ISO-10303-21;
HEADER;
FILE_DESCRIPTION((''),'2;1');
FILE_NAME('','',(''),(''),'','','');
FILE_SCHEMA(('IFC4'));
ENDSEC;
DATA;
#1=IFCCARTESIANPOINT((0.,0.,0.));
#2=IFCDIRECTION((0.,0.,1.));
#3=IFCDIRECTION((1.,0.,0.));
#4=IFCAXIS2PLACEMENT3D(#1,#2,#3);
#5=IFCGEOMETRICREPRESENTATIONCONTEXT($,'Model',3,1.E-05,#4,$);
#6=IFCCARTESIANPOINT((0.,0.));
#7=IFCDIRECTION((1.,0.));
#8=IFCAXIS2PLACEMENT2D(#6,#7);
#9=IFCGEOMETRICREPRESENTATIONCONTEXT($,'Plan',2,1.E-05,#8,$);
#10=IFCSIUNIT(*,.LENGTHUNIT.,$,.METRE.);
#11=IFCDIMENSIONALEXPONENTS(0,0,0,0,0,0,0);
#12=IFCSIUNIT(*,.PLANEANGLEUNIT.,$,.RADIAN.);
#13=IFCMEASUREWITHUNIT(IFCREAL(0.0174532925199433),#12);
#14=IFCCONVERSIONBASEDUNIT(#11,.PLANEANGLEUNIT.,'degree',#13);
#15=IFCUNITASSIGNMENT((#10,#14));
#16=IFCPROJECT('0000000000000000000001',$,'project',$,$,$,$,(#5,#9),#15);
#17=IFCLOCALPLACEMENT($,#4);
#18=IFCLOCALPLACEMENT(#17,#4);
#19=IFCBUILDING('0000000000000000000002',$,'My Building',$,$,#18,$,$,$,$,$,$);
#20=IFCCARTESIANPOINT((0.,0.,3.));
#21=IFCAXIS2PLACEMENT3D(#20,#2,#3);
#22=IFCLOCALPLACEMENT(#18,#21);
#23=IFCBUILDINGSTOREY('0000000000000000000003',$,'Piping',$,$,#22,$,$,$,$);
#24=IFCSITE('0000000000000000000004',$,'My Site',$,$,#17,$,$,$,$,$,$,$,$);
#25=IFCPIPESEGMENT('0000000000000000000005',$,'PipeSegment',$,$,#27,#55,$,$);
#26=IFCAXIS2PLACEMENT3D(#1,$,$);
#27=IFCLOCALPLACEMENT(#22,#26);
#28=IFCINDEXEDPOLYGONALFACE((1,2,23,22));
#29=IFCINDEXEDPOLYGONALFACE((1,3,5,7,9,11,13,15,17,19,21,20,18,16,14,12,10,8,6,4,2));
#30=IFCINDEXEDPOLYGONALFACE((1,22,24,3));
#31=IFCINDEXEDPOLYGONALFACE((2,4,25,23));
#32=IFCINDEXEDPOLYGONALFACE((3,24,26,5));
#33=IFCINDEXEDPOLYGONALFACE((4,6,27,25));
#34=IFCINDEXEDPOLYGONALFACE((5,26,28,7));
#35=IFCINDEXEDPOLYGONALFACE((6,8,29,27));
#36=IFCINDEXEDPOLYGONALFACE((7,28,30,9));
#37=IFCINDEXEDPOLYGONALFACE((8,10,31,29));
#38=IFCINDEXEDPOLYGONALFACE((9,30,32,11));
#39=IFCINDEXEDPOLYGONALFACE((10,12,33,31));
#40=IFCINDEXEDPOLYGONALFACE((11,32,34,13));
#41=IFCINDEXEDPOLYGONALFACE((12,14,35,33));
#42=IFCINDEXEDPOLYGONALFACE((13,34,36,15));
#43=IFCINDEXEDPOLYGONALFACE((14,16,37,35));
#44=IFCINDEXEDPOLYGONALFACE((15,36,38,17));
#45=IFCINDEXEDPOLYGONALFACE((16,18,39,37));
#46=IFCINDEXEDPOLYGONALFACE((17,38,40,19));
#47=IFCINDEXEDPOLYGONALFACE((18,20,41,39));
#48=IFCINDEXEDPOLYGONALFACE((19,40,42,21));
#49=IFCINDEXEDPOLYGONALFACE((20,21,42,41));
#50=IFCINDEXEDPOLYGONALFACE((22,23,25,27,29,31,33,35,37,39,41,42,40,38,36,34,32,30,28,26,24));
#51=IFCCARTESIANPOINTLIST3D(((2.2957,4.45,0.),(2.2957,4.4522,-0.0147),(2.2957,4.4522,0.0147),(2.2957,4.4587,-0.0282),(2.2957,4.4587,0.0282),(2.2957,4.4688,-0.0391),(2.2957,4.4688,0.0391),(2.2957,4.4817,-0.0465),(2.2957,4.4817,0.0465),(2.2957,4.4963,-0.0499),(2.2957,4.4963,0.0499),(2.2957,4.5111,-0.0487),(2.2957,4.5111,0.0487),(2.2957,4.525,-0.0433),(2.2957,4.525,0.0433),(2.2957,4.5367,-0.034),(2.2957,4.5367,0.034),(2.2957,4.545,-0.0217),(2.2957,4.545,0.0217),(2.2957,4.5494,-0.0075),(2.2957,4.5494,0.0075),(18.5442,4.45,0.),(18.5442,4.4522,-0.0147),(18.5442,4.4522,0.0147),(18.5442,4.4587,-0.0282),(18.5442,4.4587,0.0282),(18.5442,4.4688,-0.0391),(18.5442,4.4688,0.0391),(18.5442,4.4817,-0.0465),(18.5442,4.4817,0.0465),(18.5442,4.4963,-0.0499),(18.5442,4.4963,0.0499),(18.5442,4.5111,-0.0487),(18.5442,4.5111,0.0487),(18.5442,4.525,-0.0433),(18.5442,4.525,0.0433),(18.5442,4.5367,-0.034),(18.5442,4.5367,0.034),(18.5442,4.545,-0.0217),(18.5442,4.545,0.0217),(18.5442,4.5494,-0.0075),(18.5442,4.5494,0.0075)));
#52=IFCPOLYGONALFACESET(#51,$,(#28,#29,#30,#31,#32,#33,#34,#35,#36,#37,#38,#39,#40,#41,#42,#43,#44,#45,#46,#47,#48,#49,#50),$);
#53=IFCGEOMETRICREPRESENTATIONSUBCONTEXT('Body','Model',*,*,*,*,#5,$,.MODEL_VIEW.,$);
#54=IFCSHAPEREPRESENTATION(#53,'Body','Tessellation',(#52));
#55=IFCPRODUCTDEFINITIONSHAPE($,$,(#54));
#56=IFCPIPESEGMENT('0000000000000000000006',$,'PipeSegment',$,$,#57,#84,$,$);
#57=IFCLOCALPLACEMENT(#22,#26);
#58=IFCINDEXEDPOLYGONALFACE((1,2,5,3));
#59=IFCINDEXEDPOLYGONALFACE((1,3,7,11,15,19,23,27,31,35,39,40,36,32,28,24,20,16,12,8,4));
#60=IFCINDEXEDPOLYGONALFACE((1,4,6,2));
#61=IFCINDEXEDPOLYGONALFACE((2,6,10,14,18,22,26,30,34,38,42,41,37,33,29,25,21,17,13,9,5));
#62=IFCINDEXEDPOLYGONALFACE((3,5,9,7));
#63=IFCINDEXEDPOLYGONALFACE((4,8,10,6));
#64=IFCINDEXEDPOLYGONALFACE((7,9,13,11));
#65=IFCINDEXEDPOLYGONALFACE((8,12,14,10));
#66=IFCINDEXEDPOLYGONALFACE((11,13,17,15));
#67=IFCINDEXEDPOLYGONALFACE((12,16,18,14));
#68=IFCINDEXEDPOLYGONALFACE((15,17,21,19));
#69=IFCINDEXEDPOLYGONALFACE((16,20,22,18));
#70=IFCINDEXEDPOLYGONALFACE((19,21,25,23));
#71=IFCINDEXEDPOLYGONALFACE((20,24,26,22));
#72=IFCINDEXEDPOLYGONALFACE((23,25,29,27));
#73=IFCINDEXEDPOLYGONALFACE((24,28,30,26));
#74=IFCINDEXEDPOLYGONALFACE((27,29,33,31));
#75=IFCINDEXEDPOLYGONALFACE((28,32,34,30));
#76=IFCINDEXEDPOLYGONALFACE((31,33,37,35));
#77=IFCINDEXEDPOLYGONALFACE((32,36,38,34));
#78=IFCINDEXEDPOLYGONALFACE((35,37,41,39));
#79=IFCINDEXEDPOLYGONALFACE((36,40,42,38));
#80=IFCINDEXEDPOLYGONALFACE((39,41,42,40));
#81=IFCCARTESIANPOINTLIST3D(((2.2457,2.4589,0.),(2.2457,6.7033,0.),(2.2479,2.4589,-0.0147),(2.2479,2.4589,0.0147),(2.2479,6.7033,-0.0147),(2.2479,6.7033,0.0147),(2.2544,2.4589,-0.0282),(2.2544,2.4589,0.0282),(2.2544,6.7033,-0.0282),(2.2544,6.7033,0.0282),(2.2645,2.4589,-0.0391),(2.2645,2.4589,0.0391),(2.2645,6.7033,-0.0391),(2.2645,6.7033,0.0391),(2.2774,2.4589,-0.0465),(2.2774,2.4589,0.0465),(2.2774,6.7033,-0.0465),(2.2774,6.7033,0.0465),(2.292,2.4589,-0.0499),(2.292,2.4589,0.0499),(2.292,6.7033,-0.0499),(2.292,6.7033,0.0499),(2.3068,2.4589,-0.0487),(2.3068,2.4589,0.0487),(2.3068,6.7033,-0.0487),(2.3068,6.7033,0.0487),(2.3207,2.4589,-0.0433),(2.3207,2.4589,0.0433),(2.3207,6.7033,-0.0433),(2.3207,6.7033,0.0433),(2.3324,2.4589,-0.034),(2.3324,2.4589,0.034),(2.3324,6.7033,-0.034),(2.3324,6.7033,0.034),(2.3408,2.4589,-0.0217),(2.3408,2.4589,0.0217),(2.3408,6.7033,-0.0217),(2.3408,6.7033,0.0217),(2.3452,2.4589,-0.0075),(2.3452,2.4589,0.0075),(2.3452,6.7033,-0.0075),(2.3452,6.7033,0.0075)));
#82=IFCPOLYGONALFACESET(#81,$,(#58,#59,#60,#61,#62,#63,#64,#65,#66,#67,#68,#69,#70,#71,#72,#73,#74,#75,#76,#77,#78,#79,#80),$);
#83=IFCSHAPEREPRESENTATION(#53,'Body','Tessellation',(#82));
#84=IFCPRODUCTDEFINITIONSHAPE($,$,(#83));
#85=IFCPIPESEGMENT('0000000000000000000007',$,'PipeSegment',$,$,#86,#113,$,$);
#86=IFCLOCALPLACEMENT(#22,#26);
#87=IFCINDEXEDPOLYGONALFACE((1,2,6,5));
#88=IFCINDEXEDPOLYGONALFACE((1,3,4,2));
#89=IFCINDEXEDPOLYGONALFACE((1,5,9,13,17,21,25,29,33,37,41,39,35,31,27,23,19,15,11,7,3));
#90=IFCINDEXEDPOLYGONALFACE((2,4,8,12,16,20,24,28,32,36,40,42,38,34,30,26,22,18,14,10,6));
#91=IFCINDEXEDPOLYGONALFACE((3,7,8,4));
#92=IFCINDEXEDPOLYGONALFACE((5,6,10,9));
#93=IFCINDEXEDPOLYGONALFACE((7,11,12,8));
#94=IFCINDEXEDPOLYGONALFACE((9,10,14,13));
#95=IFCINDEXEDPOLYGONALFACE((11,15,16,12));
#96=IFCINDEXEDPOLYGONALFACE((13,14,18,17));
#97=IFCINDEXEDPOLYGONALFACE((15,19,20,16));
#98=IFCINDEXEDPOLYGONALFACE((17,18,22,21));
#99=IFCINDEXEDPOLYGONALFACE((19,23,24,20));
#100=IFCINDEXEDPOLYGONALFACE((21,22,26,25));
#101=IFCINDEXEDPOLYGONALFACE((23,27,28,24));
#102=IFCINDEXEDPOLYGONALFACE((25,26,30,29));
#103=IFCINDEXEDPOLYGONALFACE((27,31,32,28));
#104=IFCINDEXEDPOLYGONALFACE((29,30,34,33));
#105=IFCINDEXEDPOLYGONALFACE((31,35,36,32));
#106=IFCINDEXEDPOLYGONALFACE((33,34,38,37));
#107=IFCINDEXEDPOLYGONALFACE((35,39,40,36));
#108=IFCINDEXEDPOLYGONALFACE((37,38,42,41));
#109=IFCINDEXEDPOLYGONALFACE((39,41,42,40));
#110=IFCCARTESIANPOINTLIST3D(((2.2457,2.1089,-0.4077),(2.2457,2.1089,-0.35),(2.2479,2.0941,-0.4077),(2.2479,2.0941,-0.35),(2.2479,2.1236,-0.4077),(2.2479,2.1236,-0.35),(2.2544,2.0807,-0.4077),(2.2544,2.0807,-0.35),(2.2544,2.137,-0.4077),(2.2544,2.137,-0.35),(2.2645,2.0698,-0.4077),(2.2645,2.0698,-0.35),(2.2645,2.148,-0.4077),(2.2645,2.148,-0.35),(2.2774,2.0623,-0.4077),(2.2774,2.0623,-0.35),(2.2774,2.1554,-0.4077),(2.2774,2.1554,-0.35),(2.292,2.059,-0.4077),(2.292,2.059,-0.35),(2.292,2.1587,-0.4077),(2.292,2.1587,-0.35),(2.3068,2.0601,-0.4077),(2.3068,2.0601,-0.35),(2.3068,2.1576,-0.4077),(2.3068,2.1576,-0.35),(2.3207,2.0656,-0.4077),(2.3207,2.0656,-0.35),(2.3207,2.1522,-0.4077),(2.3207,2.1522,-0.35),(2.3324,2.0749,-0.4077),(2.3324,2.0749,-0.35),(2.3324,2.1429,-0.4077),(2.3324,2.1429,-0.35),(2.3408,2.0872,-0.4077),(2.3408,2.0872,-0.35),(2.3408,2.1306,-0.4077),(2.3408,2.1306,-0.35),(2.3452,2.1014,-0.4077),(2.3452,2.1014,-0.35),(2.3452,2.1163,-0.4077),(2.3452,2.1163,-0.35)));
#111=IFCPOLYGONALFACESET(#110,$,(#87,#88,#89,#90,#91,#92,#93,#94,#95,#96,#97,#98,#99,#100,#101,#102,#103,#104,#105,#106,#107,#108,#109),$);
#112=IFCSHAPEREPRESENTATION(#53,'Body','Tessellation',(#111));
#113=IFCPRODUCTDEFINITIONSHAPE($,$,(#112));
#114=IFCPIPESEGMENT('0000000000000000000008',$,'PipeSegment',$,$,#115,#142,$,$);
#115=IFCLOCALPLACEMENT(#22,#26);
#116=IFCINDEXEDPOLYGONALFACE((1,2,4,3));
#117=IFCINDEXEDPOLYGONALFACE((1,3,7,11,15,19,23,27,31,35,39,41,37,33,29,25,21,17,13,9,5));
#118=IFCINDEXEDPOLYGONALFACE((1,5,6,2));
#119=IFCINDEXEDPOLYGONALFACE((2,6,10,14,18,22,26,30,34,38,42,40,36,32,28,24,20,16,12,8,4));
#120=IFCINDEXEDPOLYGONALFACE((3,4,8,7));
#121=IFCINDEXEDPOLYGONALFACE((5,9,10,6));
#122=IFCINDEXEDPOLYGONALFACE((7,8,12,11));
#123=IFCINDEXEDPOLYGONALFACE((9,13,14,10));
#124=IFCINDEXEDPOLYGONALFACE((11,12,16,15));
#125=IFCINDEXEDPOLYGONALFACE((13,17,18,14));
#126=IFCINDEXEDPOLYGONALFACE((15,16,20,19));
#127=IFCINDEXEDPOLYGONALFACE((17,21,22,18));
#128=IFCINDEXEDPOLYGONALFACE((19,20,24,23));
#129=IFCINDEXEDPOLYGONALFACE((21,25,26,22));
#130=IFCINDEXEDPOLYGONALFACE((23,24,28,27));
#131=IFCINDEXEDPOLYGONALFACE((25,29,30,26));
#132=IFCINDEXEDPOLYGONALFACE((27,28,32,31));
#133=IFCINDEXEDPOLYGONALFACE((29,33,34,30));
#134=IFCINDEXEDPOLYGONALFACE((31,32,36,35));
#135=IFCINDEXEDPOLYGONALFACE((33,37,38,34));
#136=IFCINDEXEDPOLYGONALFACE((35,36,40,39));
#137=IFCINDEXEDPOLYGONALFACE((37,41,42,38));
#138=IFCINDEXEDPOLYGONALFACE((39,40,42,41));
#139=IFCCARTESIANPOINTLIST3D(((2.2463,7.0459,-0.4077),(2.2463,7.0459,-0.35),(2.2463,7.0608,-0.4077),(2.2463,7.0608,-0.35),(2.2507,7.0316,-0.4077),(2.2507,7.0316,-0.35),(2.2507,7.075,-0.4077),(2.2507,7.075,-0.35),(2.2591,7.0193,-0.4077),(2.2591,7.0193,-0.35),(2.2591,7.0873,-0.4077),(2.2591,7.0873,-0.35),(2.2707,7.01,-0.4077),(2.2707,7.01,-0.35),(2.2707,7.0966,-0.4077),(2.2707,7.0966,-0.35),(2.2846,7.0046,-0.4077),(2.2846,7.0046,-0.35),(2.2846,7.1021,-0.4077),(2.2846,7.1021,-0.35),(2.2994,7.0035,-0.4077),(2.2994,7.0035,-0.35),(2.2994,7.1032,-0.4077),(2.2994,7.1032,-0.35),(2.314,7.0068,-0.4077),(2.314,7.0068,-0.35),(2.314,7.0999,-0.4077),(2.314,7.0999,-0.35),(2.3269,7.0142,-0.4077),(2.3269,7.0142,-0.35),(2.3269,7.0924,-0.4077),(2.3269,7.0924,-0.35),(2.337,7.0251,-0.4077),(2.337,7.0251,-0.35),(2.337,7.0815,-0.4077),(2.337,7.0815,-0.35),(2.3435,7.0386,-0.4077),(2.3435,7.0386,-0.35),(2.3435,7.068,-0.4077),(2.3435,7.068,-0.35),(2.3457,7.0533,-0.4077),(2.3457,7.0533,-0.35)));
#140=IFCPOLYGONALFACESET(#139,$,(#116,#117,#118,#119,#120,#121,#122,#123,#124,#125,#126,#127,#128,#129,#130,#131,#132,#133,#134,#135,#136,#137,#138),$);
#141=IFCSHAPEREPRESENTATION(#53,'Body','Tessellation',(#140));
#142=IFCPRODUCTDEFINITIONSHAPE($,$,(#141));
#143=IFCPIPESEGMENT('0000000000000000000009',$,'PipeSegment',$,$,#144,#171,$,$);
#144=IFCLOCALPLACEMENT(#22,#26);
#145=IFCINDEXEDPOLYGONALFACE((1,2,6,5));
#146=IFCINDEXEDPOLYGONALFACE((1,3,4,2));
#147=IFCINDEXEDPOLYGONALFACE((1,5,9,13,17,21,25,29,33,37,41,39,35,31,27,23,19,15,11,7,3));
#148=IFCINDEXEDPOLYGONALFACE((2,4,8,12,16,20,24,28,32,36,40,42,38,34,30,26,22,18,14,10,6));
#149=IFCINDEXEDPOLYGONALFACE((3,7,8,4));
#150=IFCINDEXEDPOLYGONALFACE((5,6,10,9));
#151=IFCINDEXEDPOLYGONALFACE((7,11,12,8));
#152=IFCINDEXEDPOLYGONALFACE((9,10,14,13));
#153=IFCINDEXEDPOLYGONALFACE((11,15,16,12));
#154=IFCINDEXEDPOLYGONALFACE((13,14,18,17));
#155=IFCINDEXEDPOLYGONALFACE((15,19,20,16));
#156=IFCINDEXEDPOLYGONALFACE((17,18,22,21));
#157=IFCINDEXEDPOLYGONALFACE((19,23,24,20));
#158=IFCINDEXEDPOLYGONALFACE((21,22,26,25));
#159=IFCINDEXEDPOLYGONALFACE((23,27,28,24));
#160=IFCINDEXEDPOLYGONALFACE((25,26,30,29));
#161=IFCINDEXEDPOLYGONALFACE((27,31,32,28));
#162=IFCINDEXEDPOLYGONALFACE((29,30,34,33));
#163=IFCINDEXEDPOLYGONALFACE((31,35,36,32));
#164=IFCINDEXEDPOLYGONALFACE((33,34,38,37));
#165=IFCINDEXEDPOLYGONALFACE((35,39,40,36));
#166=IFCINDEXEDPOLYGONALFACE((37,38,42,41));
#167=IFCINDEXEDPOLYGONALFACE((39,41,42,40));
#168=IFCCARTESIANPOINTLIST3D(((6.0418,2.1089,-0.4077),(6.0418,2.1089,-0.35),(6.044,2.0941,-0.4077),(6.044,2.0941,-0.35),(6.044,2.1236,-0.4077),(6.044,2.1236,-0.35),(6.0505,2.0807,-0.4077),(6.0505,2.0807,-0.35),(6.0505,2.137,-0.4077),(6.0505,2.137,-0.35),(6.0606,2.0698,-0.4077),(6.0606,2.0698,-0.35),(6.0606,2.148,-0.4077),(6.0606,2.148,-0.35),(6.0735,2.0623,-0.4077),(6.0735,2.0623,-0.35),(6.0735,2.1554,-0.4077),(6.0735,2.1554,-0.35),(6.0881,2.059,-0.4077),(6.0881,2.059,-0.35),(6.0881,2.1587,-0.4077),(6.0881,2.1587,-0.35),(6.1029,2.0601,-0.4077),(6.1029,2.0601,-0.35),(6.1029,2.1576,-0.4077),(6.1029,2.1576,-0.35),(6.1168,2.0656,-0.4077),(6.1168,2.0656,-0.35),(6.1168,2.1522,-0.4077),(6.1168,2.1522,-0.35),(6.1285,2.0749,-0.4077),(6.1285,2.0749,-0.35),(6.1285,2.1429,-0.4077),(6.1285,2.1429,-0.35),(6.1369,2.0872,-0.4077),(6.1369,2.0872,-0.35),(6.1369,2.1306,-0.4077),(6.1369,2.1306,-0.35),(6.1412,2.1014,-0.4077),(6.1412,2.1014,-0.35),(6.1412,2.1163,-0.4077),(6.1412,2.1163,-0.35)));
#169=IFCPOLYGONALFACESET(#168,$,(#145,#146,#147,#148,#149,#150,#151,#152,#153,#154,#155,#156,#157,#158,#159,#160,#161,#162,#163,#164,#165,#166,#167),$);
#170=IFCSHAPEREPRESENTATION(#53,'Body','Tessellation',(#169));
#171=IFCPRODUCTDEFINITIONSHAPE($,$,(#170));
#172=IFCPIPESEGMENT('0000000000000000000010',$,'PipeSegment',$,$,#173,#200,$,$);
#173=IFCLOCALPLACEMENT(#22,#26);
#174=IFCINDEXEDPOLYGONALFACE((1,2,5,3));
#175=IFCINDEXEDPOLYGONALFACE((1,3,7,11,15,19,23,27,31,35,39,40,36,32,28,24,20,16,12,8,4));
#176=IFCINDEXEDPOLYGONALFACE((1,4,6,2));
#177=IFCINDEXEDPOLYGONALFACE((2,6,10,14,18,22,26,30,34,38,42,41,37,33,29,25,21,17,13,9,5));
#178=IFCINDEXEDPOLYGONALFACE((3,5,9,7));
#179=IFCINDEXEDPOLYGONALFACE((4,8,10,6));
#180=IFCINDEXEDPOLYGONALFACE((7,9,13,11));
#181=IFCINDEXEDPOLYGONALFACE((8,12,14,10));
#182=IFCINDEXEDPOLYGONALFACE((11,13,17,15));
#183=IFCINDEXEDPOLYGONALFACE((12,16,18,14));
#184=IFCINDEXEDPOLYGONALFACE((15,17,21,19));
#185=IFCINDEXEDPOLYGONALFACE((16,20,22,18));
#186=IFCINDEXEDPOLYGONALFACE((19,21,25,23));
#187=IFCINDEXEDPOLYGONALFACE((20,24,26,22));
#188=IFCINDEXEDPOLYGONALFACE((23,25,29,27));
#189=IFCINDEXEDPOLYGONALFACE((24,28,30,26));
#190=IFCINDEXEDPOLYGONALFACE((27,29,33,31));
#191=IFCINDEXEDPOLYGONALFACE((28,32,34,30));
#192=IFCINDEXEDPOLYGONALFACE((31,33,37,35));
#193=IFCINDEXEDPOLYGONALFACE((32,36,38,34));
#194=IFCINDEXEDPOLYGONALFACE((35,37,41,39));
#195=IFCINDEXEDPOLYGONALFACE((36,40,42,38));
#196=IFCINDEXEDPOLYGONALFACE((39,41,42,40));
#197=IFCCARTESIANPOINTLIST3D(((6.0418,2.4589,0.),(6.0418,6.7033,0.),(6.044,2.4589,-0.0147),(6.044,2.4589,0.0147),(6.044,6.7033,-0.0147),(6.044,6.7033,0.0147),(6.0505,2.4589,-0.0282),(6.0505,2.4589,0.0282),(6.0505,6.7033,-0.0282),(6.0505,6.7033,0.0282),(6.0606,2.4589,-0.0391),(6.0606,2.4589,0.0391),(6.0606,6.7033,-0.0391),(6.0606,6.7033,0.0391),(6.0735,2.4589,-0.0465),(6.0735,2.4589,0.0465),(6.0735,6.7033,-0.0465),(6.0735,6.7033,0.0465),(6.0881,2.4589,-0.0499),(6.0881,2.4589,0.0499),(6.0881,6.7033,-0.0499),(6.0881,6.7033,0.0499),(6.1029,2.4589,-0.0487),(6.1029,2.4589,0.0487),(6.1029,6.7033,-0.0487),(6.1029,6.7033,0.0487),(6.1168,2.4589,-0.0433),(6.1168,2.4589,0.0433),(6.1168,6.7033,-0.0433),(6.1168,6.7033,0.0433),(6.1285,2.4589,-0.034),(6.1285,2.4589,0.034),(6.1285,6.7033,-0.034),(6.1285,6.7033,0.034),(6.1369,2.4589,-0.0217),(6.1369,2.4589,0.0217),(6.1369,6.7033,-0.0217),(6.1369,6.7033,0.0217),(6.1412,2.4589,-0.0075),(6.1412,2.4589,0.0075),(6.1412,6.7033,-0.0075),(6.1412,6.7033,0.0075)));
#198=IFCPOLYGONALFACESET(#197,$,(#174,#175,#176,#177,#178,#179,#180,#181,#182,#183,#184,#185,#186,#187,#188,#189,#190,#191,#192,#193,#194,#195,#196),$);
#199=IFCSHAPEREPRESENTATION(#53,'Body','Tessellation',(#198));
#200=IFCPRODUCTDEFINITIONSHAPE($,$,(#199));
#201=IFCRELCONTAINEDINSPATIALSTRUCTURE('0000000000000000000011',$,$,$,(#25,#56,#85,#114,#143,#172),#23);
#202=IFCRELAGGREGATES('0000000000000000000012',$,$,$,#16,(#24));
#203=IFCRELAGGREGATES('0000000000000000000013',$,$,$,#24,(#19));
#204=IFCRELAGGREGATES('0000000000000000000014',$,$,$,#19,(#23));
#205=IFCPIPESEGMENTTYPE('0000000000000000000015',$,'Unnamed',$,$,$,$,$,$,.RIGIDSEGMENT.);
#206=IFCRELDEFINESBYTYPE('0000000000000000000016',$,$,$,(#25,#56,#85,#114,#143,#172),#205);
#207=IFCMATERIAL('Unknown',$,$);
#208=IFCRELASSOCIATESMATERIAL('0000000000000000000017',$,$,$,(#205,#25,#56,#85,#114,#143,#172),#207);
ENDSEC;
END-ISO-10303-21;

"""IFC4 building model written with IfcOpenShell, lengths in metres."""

from ifc_helpers import new_model, entity, si_unit, converted_unit, frame, origin_with_axes, origin_2d_with_axis, place, context, subcontext, project, spatial, circle, extrude, material, material_profile, profile_set, profile_usage, type_object, element, save


model = new_model("IFC4")

# Units and contexts
model_context = context("Model", 3, precision=1e-05, world=origin_with_axes())
plan_context = context("Plan", 2, precision=1e-05, world=origin_2d_with_axis())
body_context = subcontext(model_context, "Body", "Model", "MODEL_VIEW")
ifc_project = project(units=[si_unit("LENGTHUNIT", "METRE"), converted_unit("PLANEANGLEUNIT", "degree", entity("IfcReal", 0.0174532925199433), si_unit("PLANEANGLEUNIT", "RADIAN"), dimensions=[0, 0, 0, 0, 0, 0, 0])], contexts=[model_context, plan_context])

# Site, building, storey
site_placement = place(None, origin_with_axes())
site = spatial("IfcSite", under=ifc_project, at=site_placement, Name="My Site")
building_placement = place(site_placement, origin_with_axes())
building = spatial("IfcBuilding", under=site, at=building_placement, Name="My Building")
storey_placement = place(building_placement, frame((0.0, 0.0, 3.0), z_axis=(0.0, 0.0, 1.0), x_axis=(1.0, 0.0, 0.0)))
storey = spatial("IfcBuildingStorey", under=building, at=storey_placement, Name="Piping")

# Pipe segments
ifc_material = material(Name="Unknown")
ifc_material_profile = material_profile(ifc_material, circle(Radius=0.05))
ifc_profile_set = profile_set([ifc_material_profile])
ifc_profile_usage_1 = profile_usage(ifc_profile_set, cardinal=5)
pipe_segment_type = type_object("IfcPipeSegmentType", Name="Unnamed", PredefinedType="RIGIDSEGMENT", material=ifc_profile_set)
pipe_segment_1_placement = place(storey_placement, frame((18.5442, 4.5, 0.0), z_axis=(-1.0, 0.0, 0.0), x_axis=(0.0, -1.0, 0.0)))
element("IfcPipeSegment", 1, at=pipe_segment_1_placement, inside=storey, type_object=pipe_segment_type, material=ifc_profile_usage_1, Name="PipeSegment", context=body_context, shape_type="SweptSolid", body=[
    extrude(circle(Radius=0.05), origin_with_axes(), (0.0, 0.0, 1.0), 16.2484),
])
ifc_profile_usage_2 = profile_usage(ifc_profile_set, cardinal=5)
pipe_segment_2_placement = place(storey_placement, frame((2.2957, 2.4589, 0.0), z_axis=(0.0, 1.0, 0.0), x_axis=(-1.0, 0.0, 0.0)))
element("IfcPipeSegment", 2, at=pipe_segment_2_placement, inside=storey, type_object=pipe_segment_type, material=ifc_profile_usage_2, Name="PipeSegment", context=body_context, shape_type="SweptSolid", body=[
    extrude(circle(Radius=0.05), origin_with_axes(), (0.0, 0.0, 1.0), 4.2444),
])
ifc_profile_usage_3 = profile_usage(ifc_profile_set, cardinal=5)
pipe_segment_3_placement = place(storey_placement, frame((2.2957, 2.1089, -0.35), z_axis=(0.0, 0.0, -1.0), x_axis=(-1.0, 0.0, 0.0)))
element("IfcPipeSegment", 3, at=pipe_segment_3_placement, inside=storey, type_object=pipe_segment_type, material=ifc_profile_usage_3, Name="PipeSegment", context=body_context, shape_type="SweptSolid", body=[
    extrude(circle(Radius=0.05), origin_with_axes(), (0.0, 0.0, 1.0), 0.0577),
])
ifc_profile_usage_4 = profile_usage(ifc_profile_set, cardinal=5)
pipe_segment_4_placement = place(storey_placement, frame((2.2957, 7.0533, -0.35), z_axis=(0.0, 0.0, -1.0), x_axis=(1.0, 0.0, 0.0)))
element("IfcPipeSegment", 4, at=pipe_segment_4_placement, inside=storey, type_object=pipe_segment_type, material=ifc_profile_usage_4, Name="PipeSegment", context=body_context, shape_type="SweptSolid", body=[
    extrude(circle(Radius=0.05), origin_with_axes(), (0.0, 0.0, 1.0), 0.0577),
])
ifc_profile_usage_5 = profile_usage(ifc_profile_set, cardinal=5)
pipe_segment_5_placement = place(storey_placement, frame((6.0918, 2.1089, -0.35), z_axis=(0.0, 0.0, -1.0), x_axis=(-1.0, 0.0, 0.0)))
element("IfcPipeSegment", 5, at=pipe_segment_5_placement, inside=storey, type_object=pipe_segment_type, material=ifc_profile_usage_5, Name="PipeSegment", context=body_context, shape_type="SweptSolid", body=[
    extrude(circle(Radius=0.05), origin_with_axes(), (0.0, 0.0, 1.0), 0.0577),
])
ifc_profile_usage_6 = profile_usage(ifc_profile_set, cardinal=5)
pipe_segment_6_placement = place(storey_placement, frame((6.0918, 2.4589, 0.0), z_axis=(0.0, 1.0, 0.0), x_axis=(-1.0, 0.0, 0.0)))
element("IfcPipeSegment", 6, at=pipe_segment_6_placement, inside=storey, type_object=pipe_segment_type, material=ifc_profile_usage_6, Name="PipeSegment", context=body_context, shape_type="SweptSolid", body=[
    extrude(circle(Radius=0.05), origin_with_axes(), (0.0, 0.0, 1.0), 4.2444),
])

save(model, "model.ifc")
